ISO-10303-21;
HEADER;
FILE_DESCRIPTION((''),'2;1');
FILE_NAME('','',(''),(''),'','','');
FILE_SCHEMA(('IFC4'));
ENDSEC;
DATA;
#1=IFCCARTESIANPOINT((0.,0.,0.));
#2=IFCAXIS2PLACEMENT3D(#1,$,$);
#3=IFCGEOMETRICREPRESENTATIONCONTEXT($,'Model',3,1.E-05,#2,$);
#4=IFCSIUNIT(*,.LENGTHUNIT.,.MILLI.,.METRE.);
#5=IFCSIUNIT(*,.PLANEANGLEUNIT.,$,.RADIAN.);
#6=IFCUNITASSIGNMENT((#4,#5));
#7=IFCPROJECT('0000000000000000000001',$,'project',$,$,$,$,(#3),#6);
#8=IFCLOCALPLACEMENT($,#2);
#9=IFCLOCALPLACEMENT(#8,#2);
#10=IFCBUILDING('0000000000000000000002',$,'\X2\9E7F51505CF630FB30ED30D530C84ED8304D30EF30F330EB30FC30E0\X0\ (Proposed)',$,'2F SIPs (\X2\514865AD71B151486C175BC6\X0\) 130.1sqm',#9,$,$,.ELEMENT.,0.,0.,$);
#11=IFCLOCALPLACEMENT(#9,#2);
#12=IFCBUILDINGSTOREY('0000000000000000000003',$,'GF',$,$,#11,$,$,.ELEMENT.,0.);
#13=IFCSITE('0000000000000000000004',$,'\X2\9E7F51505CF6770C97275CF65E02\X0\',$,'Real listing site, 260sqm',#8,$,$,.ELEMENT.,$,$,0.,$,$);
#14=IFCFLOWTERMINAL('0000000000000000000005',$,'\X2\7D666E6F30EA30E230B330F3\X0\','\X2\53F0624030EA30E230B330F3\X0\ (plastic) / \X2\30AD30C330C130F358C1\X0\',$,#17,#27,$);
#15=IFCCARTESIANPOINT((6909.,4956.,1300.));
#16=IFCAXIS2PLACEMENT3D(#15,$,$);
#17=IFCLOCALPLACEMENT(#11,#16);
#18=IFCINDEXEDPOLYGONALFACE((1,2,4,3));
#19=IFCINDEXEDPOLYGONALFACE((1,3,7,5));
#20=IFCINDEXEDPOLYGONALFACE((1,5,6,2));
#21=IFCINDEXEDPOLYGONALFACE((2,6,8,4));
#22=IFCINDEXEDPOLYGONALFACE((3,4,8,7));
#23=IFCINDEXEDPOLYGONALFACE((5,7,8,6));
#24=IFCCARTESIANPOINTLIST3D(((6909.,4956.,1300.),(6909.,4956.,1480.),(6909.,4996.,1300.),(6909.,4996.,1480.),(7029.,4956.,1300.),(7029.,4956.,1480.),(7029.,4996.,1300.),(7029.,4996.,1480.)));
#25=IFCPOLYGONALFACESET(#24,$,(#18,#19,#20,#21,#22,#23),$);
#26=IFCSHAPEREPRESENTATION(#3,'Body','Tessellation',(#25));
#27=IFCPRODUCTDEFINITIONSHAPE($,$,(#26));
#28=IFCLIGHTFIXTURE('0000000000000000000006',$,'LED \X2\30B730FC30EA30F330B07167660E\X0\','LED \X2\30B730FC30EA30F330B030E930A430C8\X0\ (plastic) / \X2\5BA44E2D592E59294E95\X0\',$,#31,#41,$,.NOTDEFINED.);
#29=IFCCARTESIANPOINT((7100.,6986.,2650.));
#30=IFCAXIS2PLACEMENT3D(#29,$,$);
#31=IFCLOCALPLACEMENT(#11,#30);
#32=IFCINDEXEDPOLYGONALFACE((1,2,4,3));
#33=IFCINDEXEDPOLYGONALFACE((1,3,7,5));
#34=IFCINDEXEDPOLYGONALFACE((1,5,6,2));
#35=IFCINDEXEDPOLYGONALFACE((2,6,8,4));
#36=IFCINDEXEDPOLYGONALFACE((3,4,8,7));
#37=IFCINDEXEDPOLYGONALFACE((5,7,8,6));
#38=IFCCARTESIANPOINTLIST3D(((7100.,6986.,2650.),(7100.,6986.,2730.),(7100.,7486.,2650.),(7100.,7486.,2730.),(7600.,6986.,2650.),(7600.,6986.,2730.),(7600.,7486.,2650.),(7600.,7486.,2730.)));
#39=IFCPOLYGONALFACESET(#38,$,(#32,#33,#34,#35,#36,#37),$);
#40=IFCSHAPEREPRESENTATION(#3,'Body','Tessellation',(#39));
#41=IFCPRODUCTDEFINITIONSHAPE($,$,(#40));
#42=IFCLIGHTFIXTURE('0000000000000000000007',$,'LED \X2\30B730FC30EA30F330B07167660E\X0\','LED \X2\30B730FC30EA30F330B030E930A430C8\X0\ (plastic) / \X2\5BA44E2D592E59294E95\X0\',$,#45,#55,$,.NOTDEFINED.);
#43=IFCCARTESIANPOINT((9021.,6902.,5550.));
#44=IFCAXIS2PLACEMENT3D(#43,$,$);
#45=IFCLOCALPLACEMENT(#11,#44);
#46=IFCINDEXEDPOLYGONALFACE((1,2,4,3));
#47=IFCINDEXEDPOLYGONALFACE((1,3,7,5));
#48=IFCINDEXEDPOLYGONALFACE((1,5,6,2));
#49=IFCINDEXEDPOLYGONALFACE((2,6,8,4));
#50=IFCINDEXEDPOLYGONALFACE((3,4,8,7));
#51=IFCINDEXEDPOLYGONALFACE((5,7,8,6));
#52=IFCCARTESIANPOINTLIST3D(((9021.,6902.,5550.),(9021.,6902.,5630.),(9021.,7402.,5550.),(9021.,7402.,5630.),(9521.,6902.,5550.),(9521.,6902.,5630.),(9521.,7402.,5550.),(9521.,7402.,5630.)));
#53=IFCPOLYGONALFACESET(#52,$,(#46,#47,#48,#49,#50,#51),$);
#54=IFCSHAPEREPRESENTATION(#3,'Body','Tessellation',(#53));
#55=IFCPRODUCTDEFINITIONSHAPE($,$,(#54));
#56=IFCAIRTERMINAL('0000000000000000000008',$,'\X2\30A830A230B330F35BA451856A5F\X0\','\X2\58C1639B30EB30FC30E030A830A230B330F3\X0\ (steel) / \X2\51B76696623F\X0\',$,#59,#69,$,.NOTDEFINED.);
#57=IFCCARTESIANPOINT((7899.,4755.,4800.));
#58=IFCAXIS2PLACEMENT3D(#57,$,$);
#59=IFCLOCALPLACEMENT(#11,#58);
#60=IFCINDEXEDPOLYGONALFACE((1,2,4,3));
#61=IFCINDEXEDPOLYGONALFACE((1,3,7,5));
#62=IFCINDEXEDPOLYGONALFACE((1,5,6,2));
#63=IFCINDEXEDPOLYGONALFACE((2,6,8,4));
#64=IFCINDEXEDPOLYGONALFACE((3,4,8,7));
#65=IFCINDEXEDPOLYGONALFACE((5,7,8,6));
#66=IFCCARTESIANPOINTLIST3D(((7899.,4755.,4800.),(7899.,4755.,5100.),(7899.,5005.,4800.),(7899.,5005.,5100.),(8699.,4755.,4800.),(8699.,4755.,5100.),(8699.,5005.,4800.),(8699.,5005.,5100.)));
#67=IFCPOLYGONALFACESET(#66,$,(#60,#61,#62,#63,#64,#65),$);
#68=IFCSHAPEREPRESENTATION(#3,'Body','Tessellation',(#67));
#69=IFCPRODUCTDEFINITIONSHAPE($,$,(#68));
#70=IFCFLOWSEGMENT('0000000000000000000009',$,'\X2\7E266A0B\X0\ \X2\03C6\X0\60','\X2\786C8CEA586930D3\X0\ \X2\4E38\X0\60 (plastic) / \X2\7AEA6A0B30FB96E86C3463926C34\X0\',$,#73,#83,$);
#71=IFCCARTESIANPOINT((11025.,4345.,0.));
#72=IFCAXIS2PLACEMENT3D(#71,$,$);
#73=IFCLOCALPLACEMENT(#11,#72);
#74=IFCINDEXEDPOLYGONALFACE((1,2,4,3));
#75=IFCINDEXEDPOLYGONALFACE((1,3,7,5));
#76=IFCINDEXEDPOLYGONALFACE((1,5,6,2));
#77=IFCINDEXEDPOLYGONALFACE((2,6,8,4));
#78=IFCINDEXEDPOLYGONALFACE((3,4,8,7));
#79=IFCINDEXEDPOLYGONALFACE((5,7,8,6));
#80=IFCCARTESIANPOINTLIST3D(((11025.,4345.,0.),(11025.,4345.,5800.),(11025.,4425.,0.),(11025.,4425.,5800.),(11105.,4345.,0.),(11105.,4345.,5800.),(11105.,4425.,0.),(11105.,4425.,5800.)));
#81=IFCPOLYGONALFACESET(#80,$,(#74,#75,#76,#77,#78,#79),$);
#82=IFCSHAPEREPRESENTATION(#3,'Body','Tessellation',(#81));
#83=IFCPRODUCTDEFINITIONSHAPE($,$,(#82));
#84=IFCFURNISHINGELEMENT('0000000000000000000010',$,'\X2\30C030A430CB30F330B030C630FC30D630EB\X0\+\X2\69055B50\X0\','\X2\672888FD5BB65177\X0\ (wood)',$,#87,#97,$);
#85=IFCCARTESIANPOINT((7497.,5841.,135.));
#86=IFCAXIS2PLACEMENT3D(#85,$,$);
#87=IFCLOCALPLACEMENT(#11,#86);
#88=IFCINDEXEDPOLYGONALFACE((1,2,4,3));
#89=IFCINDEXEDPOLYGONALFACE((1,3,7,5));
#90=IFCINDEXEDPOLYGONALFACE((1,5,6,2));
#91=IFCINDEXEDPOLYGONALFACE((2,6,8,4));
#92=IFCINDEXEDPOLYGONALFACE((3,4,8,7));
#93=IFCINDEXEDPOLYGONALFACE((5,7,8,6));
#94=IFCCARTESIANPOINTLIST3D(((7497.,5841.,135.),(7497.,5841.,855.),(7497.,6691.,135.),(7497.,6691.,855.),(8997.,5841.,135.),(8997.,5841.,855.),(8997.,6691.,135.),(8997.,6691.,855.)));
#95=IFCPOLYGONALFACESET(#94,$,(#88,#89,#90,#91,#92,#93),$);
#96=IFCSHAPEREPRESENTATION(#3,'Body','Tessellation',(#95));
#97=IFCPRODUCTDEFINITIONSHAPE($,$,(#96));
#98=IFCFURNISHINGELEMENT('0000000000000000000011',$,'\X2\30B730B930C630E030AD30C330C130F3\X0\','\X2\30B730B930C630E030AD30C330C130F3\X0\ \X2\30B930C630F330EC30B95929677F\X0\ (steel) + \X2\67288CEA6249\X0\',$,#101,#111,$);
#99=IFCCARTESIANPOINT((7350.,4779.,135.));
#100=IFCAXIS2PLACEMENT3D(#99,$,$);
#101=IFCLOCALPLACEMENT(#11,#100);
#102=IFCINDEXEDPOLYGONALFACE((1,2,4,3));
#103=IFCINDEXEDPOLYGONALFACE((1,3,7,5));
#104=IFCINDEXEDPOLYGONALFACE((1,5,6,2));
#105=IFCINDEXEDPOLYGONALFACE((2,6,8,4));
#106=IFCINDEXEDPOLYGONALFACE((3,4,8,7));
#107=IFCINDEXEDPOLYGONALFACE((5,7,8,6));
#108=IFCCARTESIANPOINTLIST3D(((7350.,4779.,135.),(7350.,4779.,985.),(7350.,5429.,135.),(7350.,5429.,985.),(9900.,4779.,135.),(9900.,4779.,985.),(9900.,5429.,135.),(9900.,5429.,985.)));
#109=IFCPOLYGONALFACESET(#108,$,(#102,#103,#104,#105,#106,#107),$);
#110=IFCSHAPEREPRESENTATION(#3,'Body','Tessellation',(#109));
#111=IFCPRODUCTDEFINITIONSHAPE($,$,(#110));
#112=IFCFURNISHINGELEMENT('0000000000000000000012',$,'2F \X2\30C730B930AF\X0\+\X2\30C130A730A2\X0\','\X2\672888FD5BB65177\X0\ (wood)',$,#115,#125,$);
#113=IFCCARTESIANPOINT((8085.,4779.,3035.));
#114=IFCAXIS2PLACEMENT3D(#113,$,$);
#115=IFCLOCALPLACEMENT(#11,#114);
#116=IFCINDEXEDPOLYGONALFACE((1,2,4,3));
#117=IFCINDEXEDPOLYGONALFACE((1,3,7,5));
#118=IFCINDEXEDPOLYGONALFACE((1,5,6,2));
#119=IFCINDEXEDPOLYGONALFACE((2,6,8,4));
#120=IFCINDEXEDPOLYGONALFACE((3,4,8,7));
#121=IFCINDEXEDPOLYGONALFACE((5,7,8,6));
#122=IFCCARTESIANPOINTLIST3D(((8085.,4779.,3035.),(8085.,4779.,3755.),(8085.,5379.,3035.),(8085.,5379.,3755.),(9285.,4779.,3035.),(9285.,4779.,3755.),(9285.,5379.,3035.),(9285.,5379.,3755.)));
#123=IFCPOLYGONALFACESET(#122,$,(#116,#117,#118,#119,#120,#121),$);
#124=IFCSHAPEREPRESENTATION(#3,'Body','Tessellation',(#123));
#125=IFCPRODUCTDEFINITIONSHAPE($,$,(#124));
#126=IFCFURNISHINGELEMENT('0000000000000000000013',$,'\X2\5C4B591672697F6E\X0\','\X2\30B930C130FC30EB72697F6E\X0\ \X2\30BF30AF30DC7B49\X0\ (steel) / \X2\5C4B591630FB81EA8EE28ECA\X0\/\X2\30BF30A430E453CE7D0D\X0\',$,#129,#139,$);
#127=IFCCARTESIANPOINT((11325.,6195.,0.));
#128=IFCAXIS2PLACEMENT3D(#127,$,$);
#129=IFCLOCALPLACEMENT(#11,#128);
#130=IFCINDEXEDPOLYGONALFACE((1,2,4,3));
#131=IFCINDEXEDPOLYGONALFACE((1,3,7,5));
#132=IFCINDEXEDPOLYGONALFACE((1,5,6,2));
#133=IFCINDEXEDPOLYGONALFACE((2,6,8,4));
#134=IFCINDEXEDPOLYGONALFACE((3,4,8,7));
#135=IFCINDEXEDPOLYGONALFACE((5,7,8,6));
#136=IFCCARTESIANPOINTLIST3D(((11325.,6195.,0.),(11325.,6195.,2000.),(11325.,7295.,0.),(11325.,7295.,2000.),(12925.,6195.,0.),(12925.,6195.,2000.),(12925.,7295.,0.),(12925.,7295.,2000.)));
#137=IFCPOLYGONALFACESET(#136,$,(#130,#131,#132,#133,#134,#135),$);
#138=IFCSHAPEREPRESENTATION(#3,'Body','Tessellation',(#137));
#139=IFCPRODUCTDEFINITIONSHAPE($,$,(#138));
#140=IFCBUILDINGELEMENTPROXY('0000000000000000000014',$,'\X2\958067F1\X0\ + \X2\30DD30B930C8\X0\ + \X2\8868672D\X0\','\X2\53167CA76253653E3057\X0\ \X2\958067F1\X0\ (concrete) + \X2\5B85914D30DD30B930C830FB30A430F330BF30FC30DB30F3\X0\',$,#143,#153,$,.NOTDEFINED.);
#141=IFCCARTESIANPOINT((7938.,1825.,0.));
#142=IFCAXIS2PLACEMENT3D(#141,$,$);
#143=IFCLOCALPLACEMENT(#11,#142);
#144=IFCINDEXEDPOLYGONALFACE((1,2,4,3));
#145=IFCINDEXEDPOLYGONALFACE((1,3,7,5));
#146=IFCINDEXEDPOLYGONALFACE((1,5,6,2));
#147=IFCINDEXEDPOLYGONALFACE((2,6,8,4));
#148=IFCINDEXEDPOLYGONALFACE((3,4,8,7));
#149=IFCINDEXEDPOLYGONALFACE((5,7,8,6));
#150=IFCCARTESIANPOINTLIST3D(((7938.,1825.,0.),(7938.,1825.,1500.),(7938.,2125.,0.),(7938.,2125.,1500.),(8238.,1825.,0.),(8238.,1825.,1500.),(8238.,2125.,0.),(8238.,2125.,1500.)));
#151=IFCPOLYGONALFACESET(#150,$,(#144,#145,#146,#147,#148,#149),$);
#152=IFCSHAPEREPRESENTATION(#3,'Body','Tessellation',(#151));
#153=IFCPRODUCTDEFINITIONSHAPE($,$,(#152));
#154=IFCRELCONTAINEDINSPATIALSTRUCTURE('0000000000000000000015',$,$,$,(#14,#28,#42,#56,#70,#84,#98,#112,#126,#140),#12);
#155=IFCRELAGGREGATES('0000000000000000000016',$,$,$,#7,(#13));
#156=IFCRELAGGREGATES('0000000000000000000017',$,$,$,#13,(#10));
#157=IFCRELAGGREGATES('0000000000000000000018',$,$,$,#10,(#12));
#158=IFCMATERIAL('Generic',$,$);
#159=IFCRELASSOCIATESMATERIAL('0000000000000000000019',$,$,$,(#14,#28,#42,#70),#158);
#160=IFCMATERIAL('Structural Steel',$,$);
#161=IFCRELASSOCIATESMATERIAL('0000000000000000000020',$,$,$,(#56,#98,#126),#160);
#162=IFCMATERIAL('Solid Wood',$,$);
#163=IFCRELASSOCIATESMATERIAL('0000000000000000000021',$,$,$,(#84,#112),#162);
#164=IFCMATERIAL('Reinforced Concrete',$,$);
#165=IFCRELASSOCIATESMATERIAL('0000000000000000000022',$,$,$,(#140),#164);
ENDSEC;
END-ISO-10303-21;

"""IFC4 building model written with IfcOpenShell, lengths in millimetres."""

from ifc_helpers import new_model, si_unit, frame, frame_2d, origin, place, context, project, spatial, rectangle, extrude, material, element, save


model = new_model("IFC4")

# Units and contexts
model_context = context("Model", 3, precision=1e-05, world=origin())
ifc_project = project(units=[si_unit("LENGTHUNIT", "METRE", prefix="MILLI"), si_unit("PLANEANGLEUNIT", "RADIAN")], contexts=[model_context])

# Site, building, storey
site_placement = place(None, origin())
site = spatial("IfcSite", under=ifc_project, at=site_placement, Name="鹿児島県霧島市", ObjectType="Real listing site, 260sqm", CompositionType="ELEMENT", RefElevation=0.0)
building_placement = place(site_placement, origin())
building = spatial("IfcBuilding", under=site, at=building_placement, Name="鹿児島・ロフト付きワンルーム (Proposed)", ObjectType="2F SIPs (先断熱先気密) 130.1sqm", CompositionType="ELEMENT", ElevationOfRefHeight=0.0, ElevationOfTerrain=0.0)
storey_placement = place(building_placement, origin())
storey = spatial("IfcBuildingStorey", under=building, at=storey_placement, Name="GF", CompositionType="ELEMENT", Elevation=0.0)

# Shared definitions
ifc_material_1 = material(Name="Solid Wood")

# Shared definitions
ifc_material_2 = material(Name="Reinforced Concrete")

# Shared definitions
ifc_material_3 = material(Name="Structural Steel")

# Flow terminal
ifc_material_4 = material(Name="Generic")
flow_terminal_1_placement = place(storey_placement, frame((6909.0, 4956.0, 1300.0)))
element("IfcFlowTerminal", 1, at=flow_terminal_1_placement, inside=storey, material=ifc_material_4, Name="給湯リモコン", Description="台所リモコン (plastic) / キッチン壁", context=model_context, shape_type="SweptSolid", body=[
    extrude(rectangle(XDim=120.0, YDim=40.0, at=frame_2d((60.0, 20.0))), frame((6909.0, 4956.0, 1300.0)), (0.0, 0.0, 1.0), 180.0),
])

# Light fixtures
light_fixture_1_placement = place(storey_placement, frame((7100.0, 6986.0, 2650.0)))
element("IfcLightFixture", 2, at=light_fixture_1_placement, inside=storey, material=ifc_material_4, Name="LED シーリング照明", Description="LED シーリングライト (plastic) / 室中央天井", PredefinedType="NOTDEFINED", context=model_context, shape_type="SweptSolid", body=[
    extrude(rectangle(XDim=500.0, YDim=500.0, at=frame_2d((250.0, 250.0))), frame((7100.0, 6986.0, 2650.0)), (0.0, 0.0, 1.0), 80.0),
])
light_fixture_2_placement = place(storey_placement, frame((9021.0, 6902.0, 5550.0)))
element("IfcLightFixture", 3, at=light_fixture_2_placement, inside=storey, material=ifc_material_4, Name="LED シーリング照明", Description="LED シーリングライト (plastic) / 室中央天井", PredefinedType="NOTDEFINED", context=model_context, shape_type="SweptSolid", body=[
    extrude(rectangle(XDim=500.0, YDim=500.0, at=frame_2d((250.0, 250.0))), frame((9021.0, 6902.0, 5550.0)), (0.0, 0.0, 1.0), 80.0),
])

# Air terminal
air_terminal_placement = place(storey_placement, frame((7899.0, 4755.0, 4800.0)))
element("IfcAirTerminal", 4, at=air_terminal_placement, inside=storey, material=ifc_material_3, Name="エアコン室内機", Description="壁掛ルームエアコン (steel) / 冷暖房", PredefinedType="NOTDEFINED", context=model_context, shape_type="SweptSolid", body=[
    extrude(rectangle(XDim=800.0, YDim=250.0, at=frame_2d((400.0, 125.0))), frame((7899.0, 4755.0, 4800.0)), (0.0, 0.0, 1.0), 300.0),
])

# Flow segment
flow_segment_placement = place(storey_placement, frame((11025.0, 4345.0, 0.0)))
element("IfcFlowSegment", 5, at=flow_segment_placement, inside=storey, material=ifc_material_4, Name="縦樋 φ60", Description="硬質塩ビ 丸60 (plastic) / 竪樋・雨水排水", context=model_context, shape_type="SweptSolid", body=[
    extrude(rectangle(XDim=80.0, YDim=80.0, at=frame_2d((40.0, 40.0))), frame((11025.0, 4345.0, 0.0)), (0.0, 0.0, 1.0), 5800.0),
])

# Furnishing elements
furnishing_1_placement = place(storey_placement, frame((7497.0, 5841.0, 135.0)))
element("IfcFurnishingElement", 6, at=furnishing_1_placement, inside=storey, material=ifc_material_1, Name="ダイニングテーブル+椅子", Description="木製家具 (wood)", context=model_context, shape_type="SweptSolid", body=[
    extrude(rectangle(XDim=1500.0, YDim=850.0, at=frame_2d((750.0, 425.0))), frame((7497.0, 5841.0, 135.0)), (0.0, 0.0, 1.0), 720.0),
])
furnishing_2_placement = place(storey_placement, frame((7350.0, 4779.0, 135.0)))
element("IfcFurnishingElement", 7, at=furnishing_2_placement, inside=storey, material=ifc_material_3, Name="システムキッチン", Description="システムキッチン ステンレス天板 (steel) + 木質扉", context=model_context, shape_type="SweptSolid", body=[
    extrude(rectangle(XDim=2550.0, YDim=650.0, at=frame_2d((1275.0, 325.0))), frame((7350.0, 4779.0, 135.0)), (0.0, 0.0, 1.0), 850.0),
])
furnishing_3_placement = place(storey_placement, frame((8085.0, 4779.0, 3035.0)))
element("IfcFurnishingElement", 8, at=furnishing_3_placement, inside=storey, material=ifc_material_1, Name="2F デスク+チェア", Description="木製家具 (wood)", context=model_context, shape_type="SweptSolid", body=[
    extrude(rectangle(XDim=1200.0, YDim=600.0, at=frame_2d((600.0, 300.0))), frame((8085.0, 4779.0, 3035.0)), (0.0, 0.0, 1.0), 720.0),
])
furnishing_4_placement = place(storey_placement, frame((11325.0, 6195.0, 0.0)))
element("IfcFurnishingElement", 9, at=furnishing_4_placement, inside=storey, material=ifc_material_3, Name="屋外物置", Description="スチール物置 タクボ等 (steel) / 屋外・自転車/タイヤ収納", context=model_context, shape_type="SweptSolid", body=[
    extrude(rectangle(XDim=1600.0, YDim=1100.0, at=frame_2d((800.0, 550.0))), frame((11325.0, 6195.0, 0.0)), (0.0, 0.0, 1.0), 2000.0),
])

# Building element proxy
proxy_placement = place(storey_placement, frame((7938.0, 1825.0, 0.0)))
element("IfcBuildingElementProxy", 10, at=proxy_placement, inside=storey, material=ifc_material_2, Name="門柱 + ポスト + 表札", Description="化粧打放し 門柱 (concrete) + 宅配ポスト・インターホン", PredefinedType="NOTDEFINED", context=model_context, shape_type="SweptSolid", body=[
    extrude(rectangle(XDim=300.0, YDim=300.0, at=frame_2d((150.0, 150.0))), frame((7938.0, 1825.0, 0.0)), (0.0, 0.0, 1.0), 1500.0),
])

save(model, "model.ifc")
